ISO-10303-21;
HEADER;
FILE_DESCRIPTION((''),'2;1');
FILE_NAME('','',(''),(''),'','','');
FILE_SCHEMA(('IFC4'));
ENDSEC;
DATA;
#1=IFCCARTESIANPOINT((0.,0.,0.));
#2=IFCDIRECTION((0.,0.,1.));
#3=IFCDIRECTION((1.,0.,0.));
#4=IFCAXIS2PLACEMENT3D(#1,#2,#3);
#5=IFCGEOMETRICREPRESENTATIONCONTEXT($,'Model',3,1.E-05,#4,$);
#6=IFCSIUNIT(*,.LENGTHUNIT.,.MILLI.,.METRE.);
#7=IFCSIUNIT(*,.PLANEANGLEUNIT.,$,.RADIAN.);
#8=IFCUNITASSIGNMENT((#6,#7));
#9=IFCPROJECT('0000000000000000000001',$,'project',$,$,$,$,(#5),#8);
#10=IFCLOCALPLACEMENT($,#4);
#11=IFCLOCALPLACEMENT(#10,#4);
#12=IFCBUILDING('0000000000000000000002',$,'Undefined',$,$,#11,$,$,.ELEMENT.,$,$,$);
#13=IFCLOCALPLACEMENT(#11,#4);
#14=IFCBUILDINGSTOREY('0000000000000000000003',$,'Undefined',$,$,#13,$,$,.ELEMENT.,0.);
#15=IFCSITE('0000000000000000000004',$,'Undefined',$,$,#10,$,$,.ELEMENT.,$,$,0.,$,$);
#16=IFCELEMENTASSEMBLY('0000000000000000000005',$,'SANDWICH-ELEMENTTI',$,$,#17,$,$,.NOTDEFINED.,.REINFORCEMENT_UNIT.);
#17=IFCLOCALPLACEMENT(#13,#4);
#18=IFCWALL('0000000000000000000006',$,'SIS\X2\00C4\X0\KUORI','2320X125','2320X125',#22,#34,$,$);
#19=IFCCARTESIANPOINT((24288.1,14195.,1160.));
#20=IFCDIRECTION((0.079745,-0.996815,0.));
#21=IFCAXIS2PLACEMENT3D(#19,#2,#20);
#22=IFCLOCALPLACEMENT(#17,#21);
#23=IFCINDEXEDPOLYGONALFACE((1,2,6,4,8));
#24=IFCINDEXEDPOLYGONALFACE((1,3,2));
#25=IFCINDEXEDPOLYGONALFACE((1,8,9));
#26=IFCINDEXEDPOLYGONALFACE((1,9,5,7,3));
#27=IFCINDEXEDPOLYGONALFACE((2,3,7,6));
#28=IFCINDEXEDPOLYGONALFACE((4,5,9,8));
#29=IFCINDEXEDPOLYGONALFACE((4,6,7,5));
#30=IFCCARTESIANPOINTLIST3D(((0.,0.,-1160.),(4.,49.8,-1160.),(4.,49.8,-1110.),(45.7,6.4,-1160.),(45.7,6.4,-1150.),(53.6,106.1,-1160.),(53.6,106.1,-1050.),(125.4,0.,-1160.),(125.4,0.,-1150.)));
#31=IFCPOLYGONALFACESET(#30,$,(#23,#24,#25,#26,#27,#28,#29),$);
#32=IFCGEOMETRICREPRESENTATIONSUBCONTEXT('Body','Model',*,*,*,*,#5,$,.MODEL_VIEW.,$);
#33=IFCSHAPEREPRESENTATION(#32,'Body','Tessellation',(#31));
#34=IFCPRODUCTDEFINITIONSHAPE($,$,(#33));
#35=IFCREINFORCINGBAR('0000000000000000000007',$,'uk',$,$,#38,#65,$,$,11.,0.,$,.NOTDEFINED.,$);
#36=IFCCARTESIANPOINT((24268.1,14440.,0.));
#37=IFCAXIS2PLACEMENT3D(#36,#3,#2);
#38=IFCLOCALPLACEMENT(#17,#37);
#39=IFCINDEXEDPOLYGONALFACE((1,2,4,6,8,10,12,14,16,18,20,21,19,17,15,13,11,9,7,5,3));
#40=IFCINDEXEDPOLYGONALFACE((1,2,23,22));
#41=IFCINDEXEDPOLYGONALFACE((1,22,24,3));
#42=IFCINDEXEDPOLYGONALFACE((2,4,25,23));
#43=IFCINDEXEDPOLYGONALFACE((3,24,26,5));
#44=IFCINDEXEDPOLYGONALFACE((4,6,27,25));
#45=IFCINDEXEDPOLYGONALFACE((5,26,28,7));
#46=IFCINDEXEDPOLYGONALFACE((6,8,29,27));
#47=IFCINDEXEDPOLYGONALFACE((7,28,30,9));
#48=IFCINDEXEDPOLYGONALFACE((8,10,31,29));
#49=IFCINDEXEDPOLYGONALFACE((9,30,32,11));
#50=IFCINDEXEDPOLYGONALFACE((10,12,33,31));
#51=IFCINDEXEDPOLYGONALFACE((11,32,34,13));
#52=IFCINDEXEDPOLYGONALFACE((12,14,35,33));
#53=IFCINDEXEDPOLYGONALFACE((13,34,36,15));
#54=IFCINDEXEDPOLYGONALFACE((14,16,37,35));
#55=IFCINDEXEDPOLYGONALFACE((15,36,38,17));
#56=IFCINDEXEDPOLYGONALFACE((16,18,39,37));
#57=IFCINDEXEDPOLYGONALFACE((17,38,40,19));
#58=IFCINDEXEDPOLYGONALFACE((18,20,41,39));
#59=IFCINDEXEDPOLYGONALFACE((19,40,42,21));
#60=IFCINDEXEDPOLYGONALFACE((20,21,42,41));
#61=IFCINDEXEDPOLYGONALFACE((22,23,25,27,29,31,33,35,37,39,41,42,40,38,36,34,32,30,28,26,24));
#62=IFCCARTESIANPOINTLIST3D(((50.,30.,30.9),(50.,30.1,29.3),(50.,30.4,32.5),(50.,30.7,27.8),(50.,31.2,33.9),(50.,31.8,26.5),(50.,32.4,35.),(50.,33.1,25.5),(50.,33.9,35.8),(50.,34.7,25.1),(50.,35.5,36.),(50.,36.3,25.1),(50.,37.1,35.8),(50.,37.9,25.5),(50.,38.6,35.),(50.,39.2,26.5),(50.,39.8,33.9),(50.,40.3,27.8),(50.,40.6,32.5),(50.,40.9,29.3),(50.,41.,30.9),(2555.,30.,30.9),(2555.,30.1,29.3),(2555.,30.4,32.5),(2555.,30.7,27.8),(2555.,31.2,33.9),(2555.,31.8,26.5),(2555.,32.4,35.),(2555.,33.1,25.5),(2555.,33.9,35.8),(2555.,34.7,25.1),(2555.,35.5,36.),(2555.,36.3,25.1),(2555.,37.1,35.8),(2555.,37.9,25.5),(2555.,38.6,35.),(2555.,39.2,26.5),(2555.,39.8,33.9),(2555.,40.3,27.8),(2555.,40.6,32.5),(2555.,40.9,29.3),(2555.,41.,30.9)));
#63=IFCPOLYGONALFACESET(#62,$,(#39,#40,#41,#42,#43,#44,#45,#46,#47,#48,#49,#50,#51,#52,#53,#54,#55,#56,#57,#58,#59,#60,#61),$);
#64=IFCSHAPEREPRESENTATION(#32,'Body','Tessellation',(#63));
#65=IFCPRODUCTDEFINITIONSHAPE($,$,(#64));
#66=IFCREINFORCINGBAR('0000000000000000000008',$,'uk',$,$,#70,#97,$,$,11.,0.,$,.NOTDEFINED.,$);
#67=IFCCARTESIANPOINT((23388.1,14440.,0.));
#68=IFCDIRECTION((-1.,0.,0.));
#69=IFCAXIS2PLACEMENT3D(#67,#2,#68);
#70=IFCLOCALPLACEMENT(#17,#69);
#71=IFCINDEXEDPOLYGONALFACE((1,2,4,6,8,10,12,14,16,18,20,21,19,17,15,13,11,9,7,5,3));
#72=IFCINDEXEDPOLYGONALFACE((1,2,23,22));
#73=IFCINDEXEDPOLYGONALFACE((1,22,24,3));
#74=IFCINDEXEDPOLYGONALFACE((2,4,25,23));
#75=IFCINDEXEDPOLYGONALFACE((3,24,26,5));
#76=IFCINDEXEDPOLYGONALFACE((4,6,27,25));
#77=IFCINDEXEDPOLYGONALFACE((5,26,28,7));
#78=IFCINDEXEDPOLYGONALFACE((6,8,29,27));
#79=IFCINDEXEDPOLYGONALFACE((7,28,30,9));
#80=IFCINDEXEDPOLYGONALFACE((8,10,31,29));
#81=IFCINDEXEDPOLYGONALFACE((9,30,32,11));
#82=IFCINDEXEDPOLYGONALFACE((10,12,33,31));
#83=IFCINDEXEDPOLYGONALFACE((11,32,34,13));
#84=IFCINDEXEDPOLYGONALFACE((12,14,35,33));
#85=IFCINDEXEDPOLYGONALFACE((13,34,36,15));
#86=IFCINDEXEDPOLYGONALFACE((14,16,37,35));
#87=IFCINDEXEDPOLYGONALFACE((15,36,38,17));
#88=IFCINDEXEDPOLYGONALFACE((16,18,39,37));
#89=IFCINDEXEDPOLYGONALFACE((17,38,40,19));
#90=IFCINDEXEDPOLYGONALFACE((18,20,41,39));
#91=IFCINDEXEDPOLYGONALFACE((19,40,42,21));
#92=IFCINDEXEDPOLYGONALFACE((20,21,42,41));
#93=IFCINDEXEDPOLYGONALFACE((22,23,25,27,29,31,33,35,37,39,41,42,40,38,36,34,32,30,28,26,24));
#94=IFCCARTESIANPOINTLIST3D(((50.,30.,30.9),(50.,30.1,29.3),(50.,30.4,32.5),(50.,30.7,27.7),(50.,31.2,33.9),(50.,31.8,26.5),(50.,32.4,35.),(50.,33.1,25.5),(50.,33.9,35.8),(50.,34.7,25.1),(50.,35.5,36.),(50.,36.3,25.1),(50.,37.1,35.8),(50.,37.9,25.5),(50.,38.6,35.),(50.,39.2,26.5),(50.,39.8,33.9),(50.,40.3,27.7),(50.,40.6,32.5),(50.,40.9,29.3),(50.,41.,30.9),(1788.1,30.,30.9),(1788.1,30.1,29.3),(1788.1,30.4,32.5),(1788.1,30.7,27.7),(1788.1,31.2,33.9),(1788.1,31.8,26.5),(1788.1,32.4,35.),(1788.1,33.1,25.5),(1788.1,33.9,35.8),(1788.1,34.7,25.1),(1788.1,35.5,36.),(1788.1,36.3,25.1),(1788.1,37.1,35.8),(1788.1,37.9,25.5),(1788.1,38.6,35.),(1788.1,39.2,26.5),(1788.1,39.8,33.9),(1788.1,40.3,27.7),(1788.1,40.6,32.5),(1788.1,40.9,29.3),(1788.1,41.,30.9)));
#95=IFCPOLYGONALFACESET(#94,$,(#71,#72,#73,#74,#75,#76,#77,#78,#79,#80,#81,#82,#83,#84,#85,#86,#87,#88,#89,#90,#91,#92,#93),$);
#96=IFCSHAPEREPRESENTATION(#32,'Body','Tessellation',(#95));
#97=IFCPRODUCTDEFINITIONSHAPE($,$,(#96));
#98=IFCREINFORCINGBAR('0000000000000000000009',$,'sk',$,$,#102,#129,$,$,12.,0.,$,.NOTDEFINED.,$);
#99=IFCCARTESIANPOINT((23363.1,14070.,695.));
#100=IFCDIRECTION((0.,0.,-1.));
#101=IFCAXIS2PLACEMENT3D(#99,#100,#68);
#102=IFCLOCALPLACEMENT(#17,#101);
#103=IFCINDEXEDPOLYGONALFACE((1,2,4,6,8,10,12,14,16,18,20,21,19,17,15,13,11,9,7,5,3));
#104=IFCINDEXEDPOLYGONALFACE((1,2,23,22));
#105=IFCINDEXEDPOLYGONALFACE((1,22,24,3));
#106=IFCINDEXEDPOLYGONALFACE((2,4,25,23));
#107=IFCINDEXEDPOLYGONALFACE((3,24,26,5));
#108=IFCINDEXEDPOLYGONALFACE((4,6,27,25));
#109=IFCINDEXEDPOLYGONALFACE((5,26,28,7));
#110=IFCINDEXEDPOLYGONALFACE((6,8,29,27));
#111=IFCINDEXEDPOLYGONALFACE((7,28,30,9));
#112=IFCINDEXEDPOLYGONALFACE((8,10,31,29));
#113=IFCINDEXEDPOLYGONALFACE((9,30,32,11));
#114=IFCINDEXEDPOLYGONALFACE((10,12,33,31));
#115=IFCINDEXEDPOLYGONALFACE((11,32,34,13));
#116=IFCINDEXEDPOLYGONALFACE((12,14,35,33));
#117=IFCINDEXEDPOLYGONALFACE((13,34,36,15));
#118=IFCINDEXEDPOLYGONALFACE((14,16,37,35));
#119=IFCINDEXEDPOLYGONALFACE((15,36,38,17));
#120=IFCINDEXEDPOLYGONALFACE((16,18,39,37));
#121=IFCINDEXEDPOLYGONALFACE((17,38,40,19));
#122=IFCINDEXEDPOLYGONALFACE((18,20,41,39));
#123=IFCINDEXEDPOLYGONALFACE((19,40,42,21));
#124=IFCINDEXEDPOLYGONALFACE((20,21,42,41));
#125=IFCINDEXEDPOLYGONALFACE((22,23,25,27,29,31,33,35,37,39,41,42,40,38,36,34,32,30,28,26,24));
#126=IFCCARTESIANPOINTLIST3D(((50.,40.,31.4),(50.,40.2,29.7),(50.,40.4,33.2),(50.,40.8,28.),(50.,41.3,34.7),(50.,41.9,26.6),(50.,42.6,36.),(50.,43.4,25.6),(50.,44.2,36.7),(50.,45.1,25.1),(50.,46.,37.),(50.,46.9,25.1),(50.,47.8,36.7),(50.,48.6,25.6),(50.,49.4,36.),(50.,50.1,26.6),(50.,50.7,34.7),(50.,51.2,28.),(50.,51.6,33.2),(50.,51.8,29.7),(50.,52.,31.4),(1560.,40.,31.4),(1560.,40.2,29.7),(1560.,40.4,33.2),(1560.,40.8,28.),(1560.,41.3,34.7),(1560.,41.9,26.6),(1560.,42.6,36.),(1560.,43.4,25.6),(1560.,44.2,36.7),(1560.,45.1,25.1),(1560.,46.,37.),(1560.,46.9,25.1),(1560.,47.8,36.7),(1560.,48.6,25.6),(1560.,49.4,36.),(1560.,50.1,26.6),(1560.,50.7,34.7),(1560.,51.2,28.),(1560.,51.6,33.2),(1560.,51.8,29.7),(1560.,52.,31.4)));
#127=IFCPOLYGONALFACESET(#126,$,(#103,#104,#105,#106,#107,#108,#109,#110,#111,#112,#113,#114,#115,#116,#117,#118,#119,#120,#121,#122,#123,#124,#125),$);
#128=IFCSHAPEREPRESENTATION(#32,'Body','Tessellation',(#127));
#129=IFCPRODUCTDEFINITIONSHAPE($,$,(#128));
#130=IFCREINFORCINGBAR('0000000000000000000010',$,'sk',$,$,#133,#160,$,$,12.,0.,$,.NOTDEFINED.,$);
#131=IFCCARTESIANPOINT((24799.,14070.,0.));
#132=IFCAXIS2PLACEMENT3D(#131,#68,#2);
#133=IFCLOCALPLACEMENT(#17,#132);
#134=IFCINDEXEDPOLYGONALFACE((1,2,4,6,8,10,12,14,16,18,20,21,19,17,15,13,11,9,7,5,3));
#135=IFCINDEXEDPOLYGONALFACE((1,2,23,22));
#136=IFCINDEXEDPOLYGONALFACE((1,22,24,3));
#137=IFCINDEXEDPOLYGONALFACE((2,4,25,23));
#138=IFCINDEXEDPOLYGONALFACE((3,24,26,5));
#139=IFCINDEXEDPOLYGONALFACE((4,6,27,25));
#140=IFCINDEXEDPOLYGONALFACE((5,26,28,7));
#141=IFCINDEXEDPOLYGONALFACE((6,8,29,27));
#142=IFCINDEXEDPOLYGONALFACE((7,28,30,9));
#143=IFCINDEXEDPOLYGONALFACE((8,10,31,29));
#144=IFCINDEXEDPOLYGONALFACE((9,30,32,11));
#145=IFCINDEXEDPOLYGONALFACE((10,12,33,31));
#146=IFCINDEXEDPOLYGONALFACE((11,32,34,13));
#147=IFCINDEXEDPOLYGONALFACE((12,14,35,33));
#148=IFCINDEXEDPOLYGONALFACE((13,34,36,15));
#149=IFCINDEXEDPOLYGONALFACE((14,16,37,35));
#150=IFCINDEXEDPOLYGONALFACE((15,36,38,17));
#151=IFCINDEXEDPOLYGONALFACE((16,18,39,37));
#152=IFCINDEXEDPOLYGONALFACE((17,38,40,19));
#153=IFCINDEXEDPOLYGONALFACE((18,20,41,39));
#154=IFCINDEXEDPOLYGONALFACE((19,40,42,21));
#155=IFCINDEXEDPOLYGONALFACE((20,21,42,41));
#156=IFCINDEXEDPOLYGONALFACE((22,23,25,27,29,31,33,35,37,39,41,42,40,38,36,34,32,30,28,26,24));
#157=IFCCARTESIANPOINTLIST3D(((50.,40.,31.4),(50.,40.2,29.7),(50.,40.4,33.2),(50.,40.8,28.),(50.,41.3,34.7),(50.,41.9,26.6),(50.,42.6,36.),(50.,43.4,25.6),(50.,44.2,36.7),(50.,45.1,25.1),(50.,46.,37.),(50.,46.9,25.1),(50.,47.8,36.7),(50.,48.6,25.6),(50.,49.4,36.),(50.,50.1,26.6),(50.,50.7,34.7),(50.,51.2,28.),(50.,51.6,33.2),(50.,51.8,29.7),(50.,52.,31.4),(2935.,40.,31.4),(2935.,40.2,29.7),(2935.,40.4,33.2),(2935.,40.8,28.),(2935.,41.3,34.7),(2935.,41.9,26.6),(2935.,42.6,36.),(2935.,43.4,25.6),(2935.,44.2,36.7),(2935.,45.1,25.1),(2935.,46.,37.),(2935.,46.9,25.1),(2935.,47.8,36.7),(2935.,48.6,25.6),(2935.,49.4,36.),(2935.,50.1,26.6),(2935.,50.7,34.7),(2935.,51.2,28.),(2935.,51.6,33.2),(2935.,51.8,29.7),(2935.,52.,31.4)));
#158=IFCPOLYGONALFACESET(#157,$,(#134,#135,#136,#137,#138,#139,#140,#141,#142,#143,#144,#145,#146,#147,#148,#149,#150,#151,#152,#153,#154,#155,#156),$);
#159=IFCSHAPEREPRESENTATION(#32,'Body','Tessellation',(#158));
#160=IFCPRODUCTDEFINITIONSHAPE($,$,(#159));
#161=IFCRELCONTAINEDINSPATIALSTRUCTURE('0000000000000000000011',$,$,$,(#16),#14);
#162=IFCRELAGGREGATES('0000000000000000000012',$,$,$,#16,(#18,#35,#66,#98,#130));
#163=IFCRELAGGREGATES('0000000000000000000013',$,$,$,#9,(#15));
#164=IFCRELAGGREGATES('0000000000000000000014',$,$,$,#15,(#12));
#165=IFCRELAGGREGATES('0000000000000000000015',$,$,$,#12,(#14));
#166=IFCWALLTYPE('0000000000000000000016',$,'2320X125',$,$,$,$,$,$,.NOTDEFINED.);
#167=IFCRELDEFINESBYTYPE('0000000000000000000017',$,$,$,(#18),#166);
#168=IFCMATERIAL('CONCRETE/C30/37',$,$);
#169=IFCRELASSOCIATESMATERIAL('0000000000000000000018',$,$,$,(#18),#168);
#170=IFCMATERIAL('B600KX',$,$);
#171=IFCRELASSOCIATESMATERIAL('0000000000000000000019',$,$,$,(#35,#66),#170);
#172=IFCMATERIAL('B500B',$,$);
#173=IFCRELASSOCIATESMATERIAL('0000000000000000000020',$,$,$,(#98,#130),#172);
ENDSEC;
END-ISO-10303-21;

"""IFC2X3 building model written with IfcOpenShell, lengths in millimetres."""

from ifc_helpers import new_model, entity, si_unit, frame, origin_with_axes, place, context, subcontext, project, spatial, polyline, outline, extrude, clip, halfspace, source, transform, mapped, material, type_object, element, aggregate, save


model = new_model("IFC2X3")

# Units and contexts
model_context = context("Model", 3, precision=1e-05, world=origin_with_axes())
body_context = subcontext(model_context, "Body", "Model", "MODEL_VIEW")
ifc_project = project(units=[si_unit("LENGTHUNIT", "METRE", prefix="MILLI"), si_unit("PLANEANGLEUNIT", "RADIAN")], contexts=[model_context])

# Site, building, storey
site_placement = place(None, origin_with_axes())
site = spatial("IfcSite", under=ifc_project, at=site_placement, Name="Undefined", CompositionType="ELEMENT", RefElevation=0.0)
building_placement = place(site_placement, origin_with_axes())
building = spatial("IfcBuilding", under=site, at=building_placement, Name="Undefined", CompositionType="ELEMENT")
storey_placement = place(building_placement, origin_with_axes())
storey = spatial("IfcBuildingStorey", under=building, at=storey_placement, Name="Undefined", CompositionType="ELEMENT", Elevation=0.0)

# Element assembly, wall
assembly_1_placement = place(storey_placement, origin_with_axes())
assembly_1 = element("IfcElementAssembly", 1, at=assembly_1_placement, inside=storey, Name="SANDWICH-ELEMENTTI", AssemblyPlace="NOTDEFINED", PredefinedType="REINFORCEMENT_UNIT")
ifc_material_1 = material(Name="CONCRETE/C30/37")
wall_type_1 = type_object("IfcWallType", Name="2320X125", PredefinedType="NOTDEFINED")
wall_1_placement = place(assembly_1_placement, frame((24288.1, 14195.0, 1160.0), z_axis=(0.0, 0.0, 1.0), x_axis=(0.079745, -0.996815, 0.0)))
wall_1 = element("IfcWall", 2, at=wall_1_placement, type_object=wall_type_1, material=ifc_material_1, Name="SISÄKUORI", Description="2320X125", ObjectType="2320X125", context=body_context, shape_type="Clipping", body=[
    clip(extrude(outline(polyline([(0.0, 0.0), (125.4, 0.0), (45.7, 6.4), (53.6, 106.1), (4.0, 49.8), (0.0, 0.0)])), frame((0.0, 0.0, -1160.0), z_axis=(0.0, 0.0, 1.0), x_axis=(1.0, 0.0, 0.0)), (0.0, 0.0, 1.0), 2430.0), halfspace(frame((0.0, 0.0, -1160.0), z_axis=(-0.056388, -0.704855, 0.707107), x_axis=(0.056388, 0.704855, 0.707107)), False)),
])

# Reinforcing bars
ifc_material_2 = material(Name="B600KX")
shared_shape_1 = source(origin_with_axes(), body_context, "Body", "AdvancedSweptSolid", [
    entity("IfcSweptDiskSolid", entity("IfcTrimmedCurve", entity("IfcLine", entity("IfcCartesianPoint", [0.0, 0.0, 0.0]), entity("IfcVector", entity("IfcDirection", [1.0, 0.0, 0.0]), 1.0)), [entity("IfcParameterValue", 0.0)], [entity("IfcParameterValue", 2505.0001)], True, "PARAMETER"), 5.5, None, 0.0, 2505.0),
])
reinforcing_bar_1_placement = place(assembly_1_placement, frame((24268.1, 14440.0, 0.0), z_axis=(1.0, 0.0, 0.0), x_axis=(0.0, 0.0, 1.0)))
reinforcing_bar_1 = element("IfcReinforcingBar", 3, at=reinforcing_bar_1_placement, material=ifc_material_2, Name="uk", BarRole="NOTDEFINED", CrossSectionArea=0.0, NominalDiameter=11.0, context=body_context, shape_type="MappedRepresentation", body=[
    mapped(shared_shape_1, transform((50.0, 35.5, 30.5))),
])
shared_shape_2 = source(origin_with_axes(), body_context, "Body", "AdvancedSweptSolid", [
    entity("IfcSweptDiskSolid", entity("IfcTrimmedCurve", entity("IfcLine", entity("IfcCartesianPoint", [0.0, 0.0, 0.0]), entity("IfcVector", entity("IfcDirection", [1.0, 0.0, 0.0]), 1.0)), [entity("IfcParameterValue", 0.0)], [entity("IfcParameterValue", 1738.1224)], True, "PARAMETER"), 5.5, None, 0.0, 1738.1),
])
reinforcing_bar_2_placement = place(assembly_1_placement, frame((23388.1, 14440.0, 0.0), z_axis=(0.0, 0.0, 1.0), x_axis=(-1.0, 0.0, 0.0)))
reinforcing_bar_2 = element("IfcReinforcingBar", 4, at=reinforcing_bar_2_placement, material=ifc_material_2, Name="uk", BarRole="NOTDEFINED", CrossSectionArea=0.0, NominalDiameter=11.0, context=body_context, shape_type="MappedRepresentation", body=[
    mapped(shared_shape_2, transform((50.0, 35.5, 30.5))),
])
ifc_material_3 = material(Name="B500B")
shared_shape_3 = source(origin_with_axes(), body_context, "Body", "AdvancedSweptSolid", [
    entity("IfcSweptDiskSolid", entity("IfcTrimmedCurve", entity("IfcLine", entity("IfcCartesianPoint", [0.0, 0.0, 0.0]), entity("IfcVector", entity("IfcDirection", [1.0, 0.0, 0.0]), 1.0)), [entity("IfcParameterValue", 0.0)], [entity("IfcParameterValue", 1510.0002)], True, "PARAMETER"), 6.0, None, 0.0, 1510.0),
])
reinforcing_bar_3_placement = place(assembly_1_placement, frame((23363.1, 14070.0, 695.0), z_axis=(0.0, 0.0, -1.0), x_axis=(-1.0, 0.0, 0.0)))
reinforcing_bar_3 = element("IfcReinforcingBar", 5, at=reinforcing_bar_3_placement, material=ifc_material_3, Name="sk", BarRole="NOTDEFINED", CrossSectionArea=0.0, NominalDiameter=12.0, context=body_context, shape_type="MappedRepresentation", body=[
    mapped(shared_shape_3, transform((50.0, 46.0, 31.0))),
])
shared_shape_4 = source(origin_with_axes(), body_context, "Body", "AdvancedSweptSolid", [
    entity("IfcSweptDiskSolid", entity("IfcTrimmedCurve", entity("IfcLine", entity("IfcCartesianPoint", [0.0, 0.0, 0.0]), entity("IfcVector", entity("IfcDirection", [1.0, 0.0, 0.0]), 1.0)), [entity("IfcParameterValue", 0.0)], [entity("IfcParameterValue", 2885.0002)], True, "PARAMETER"), 6.0, None, 0.0, 2885.0),
])
reinforcing_bar_4_placement = place(assembly_1_placement, frame((24799.0, 14070.0, 0.0), z_axis=(-1.0, 0.0, 0.0), x_axis=(0.0, 0.0, 1.0)))
reinforcing_bar_4 = element("IfcReinforcingBar", 6, at=reinforcing_bar_4_placement, material=ifc_material_3, Name="sk", BarRole="NOTDEFINED", CrossSectionArea=0.0, NominalDiameter=12.0, context=body_context, shape_type="MappedRepresentation", body=[
    mapped(shared_shape_4, transform((50.0, 46.0, 31.0))),
])
aggregate(assembly_1, [wall_1, reinforcing_bar_1, reinforcing_bar_2, reinforcing_bar_3, reinforcing_bar_4])

save(model, "model.ifc")
